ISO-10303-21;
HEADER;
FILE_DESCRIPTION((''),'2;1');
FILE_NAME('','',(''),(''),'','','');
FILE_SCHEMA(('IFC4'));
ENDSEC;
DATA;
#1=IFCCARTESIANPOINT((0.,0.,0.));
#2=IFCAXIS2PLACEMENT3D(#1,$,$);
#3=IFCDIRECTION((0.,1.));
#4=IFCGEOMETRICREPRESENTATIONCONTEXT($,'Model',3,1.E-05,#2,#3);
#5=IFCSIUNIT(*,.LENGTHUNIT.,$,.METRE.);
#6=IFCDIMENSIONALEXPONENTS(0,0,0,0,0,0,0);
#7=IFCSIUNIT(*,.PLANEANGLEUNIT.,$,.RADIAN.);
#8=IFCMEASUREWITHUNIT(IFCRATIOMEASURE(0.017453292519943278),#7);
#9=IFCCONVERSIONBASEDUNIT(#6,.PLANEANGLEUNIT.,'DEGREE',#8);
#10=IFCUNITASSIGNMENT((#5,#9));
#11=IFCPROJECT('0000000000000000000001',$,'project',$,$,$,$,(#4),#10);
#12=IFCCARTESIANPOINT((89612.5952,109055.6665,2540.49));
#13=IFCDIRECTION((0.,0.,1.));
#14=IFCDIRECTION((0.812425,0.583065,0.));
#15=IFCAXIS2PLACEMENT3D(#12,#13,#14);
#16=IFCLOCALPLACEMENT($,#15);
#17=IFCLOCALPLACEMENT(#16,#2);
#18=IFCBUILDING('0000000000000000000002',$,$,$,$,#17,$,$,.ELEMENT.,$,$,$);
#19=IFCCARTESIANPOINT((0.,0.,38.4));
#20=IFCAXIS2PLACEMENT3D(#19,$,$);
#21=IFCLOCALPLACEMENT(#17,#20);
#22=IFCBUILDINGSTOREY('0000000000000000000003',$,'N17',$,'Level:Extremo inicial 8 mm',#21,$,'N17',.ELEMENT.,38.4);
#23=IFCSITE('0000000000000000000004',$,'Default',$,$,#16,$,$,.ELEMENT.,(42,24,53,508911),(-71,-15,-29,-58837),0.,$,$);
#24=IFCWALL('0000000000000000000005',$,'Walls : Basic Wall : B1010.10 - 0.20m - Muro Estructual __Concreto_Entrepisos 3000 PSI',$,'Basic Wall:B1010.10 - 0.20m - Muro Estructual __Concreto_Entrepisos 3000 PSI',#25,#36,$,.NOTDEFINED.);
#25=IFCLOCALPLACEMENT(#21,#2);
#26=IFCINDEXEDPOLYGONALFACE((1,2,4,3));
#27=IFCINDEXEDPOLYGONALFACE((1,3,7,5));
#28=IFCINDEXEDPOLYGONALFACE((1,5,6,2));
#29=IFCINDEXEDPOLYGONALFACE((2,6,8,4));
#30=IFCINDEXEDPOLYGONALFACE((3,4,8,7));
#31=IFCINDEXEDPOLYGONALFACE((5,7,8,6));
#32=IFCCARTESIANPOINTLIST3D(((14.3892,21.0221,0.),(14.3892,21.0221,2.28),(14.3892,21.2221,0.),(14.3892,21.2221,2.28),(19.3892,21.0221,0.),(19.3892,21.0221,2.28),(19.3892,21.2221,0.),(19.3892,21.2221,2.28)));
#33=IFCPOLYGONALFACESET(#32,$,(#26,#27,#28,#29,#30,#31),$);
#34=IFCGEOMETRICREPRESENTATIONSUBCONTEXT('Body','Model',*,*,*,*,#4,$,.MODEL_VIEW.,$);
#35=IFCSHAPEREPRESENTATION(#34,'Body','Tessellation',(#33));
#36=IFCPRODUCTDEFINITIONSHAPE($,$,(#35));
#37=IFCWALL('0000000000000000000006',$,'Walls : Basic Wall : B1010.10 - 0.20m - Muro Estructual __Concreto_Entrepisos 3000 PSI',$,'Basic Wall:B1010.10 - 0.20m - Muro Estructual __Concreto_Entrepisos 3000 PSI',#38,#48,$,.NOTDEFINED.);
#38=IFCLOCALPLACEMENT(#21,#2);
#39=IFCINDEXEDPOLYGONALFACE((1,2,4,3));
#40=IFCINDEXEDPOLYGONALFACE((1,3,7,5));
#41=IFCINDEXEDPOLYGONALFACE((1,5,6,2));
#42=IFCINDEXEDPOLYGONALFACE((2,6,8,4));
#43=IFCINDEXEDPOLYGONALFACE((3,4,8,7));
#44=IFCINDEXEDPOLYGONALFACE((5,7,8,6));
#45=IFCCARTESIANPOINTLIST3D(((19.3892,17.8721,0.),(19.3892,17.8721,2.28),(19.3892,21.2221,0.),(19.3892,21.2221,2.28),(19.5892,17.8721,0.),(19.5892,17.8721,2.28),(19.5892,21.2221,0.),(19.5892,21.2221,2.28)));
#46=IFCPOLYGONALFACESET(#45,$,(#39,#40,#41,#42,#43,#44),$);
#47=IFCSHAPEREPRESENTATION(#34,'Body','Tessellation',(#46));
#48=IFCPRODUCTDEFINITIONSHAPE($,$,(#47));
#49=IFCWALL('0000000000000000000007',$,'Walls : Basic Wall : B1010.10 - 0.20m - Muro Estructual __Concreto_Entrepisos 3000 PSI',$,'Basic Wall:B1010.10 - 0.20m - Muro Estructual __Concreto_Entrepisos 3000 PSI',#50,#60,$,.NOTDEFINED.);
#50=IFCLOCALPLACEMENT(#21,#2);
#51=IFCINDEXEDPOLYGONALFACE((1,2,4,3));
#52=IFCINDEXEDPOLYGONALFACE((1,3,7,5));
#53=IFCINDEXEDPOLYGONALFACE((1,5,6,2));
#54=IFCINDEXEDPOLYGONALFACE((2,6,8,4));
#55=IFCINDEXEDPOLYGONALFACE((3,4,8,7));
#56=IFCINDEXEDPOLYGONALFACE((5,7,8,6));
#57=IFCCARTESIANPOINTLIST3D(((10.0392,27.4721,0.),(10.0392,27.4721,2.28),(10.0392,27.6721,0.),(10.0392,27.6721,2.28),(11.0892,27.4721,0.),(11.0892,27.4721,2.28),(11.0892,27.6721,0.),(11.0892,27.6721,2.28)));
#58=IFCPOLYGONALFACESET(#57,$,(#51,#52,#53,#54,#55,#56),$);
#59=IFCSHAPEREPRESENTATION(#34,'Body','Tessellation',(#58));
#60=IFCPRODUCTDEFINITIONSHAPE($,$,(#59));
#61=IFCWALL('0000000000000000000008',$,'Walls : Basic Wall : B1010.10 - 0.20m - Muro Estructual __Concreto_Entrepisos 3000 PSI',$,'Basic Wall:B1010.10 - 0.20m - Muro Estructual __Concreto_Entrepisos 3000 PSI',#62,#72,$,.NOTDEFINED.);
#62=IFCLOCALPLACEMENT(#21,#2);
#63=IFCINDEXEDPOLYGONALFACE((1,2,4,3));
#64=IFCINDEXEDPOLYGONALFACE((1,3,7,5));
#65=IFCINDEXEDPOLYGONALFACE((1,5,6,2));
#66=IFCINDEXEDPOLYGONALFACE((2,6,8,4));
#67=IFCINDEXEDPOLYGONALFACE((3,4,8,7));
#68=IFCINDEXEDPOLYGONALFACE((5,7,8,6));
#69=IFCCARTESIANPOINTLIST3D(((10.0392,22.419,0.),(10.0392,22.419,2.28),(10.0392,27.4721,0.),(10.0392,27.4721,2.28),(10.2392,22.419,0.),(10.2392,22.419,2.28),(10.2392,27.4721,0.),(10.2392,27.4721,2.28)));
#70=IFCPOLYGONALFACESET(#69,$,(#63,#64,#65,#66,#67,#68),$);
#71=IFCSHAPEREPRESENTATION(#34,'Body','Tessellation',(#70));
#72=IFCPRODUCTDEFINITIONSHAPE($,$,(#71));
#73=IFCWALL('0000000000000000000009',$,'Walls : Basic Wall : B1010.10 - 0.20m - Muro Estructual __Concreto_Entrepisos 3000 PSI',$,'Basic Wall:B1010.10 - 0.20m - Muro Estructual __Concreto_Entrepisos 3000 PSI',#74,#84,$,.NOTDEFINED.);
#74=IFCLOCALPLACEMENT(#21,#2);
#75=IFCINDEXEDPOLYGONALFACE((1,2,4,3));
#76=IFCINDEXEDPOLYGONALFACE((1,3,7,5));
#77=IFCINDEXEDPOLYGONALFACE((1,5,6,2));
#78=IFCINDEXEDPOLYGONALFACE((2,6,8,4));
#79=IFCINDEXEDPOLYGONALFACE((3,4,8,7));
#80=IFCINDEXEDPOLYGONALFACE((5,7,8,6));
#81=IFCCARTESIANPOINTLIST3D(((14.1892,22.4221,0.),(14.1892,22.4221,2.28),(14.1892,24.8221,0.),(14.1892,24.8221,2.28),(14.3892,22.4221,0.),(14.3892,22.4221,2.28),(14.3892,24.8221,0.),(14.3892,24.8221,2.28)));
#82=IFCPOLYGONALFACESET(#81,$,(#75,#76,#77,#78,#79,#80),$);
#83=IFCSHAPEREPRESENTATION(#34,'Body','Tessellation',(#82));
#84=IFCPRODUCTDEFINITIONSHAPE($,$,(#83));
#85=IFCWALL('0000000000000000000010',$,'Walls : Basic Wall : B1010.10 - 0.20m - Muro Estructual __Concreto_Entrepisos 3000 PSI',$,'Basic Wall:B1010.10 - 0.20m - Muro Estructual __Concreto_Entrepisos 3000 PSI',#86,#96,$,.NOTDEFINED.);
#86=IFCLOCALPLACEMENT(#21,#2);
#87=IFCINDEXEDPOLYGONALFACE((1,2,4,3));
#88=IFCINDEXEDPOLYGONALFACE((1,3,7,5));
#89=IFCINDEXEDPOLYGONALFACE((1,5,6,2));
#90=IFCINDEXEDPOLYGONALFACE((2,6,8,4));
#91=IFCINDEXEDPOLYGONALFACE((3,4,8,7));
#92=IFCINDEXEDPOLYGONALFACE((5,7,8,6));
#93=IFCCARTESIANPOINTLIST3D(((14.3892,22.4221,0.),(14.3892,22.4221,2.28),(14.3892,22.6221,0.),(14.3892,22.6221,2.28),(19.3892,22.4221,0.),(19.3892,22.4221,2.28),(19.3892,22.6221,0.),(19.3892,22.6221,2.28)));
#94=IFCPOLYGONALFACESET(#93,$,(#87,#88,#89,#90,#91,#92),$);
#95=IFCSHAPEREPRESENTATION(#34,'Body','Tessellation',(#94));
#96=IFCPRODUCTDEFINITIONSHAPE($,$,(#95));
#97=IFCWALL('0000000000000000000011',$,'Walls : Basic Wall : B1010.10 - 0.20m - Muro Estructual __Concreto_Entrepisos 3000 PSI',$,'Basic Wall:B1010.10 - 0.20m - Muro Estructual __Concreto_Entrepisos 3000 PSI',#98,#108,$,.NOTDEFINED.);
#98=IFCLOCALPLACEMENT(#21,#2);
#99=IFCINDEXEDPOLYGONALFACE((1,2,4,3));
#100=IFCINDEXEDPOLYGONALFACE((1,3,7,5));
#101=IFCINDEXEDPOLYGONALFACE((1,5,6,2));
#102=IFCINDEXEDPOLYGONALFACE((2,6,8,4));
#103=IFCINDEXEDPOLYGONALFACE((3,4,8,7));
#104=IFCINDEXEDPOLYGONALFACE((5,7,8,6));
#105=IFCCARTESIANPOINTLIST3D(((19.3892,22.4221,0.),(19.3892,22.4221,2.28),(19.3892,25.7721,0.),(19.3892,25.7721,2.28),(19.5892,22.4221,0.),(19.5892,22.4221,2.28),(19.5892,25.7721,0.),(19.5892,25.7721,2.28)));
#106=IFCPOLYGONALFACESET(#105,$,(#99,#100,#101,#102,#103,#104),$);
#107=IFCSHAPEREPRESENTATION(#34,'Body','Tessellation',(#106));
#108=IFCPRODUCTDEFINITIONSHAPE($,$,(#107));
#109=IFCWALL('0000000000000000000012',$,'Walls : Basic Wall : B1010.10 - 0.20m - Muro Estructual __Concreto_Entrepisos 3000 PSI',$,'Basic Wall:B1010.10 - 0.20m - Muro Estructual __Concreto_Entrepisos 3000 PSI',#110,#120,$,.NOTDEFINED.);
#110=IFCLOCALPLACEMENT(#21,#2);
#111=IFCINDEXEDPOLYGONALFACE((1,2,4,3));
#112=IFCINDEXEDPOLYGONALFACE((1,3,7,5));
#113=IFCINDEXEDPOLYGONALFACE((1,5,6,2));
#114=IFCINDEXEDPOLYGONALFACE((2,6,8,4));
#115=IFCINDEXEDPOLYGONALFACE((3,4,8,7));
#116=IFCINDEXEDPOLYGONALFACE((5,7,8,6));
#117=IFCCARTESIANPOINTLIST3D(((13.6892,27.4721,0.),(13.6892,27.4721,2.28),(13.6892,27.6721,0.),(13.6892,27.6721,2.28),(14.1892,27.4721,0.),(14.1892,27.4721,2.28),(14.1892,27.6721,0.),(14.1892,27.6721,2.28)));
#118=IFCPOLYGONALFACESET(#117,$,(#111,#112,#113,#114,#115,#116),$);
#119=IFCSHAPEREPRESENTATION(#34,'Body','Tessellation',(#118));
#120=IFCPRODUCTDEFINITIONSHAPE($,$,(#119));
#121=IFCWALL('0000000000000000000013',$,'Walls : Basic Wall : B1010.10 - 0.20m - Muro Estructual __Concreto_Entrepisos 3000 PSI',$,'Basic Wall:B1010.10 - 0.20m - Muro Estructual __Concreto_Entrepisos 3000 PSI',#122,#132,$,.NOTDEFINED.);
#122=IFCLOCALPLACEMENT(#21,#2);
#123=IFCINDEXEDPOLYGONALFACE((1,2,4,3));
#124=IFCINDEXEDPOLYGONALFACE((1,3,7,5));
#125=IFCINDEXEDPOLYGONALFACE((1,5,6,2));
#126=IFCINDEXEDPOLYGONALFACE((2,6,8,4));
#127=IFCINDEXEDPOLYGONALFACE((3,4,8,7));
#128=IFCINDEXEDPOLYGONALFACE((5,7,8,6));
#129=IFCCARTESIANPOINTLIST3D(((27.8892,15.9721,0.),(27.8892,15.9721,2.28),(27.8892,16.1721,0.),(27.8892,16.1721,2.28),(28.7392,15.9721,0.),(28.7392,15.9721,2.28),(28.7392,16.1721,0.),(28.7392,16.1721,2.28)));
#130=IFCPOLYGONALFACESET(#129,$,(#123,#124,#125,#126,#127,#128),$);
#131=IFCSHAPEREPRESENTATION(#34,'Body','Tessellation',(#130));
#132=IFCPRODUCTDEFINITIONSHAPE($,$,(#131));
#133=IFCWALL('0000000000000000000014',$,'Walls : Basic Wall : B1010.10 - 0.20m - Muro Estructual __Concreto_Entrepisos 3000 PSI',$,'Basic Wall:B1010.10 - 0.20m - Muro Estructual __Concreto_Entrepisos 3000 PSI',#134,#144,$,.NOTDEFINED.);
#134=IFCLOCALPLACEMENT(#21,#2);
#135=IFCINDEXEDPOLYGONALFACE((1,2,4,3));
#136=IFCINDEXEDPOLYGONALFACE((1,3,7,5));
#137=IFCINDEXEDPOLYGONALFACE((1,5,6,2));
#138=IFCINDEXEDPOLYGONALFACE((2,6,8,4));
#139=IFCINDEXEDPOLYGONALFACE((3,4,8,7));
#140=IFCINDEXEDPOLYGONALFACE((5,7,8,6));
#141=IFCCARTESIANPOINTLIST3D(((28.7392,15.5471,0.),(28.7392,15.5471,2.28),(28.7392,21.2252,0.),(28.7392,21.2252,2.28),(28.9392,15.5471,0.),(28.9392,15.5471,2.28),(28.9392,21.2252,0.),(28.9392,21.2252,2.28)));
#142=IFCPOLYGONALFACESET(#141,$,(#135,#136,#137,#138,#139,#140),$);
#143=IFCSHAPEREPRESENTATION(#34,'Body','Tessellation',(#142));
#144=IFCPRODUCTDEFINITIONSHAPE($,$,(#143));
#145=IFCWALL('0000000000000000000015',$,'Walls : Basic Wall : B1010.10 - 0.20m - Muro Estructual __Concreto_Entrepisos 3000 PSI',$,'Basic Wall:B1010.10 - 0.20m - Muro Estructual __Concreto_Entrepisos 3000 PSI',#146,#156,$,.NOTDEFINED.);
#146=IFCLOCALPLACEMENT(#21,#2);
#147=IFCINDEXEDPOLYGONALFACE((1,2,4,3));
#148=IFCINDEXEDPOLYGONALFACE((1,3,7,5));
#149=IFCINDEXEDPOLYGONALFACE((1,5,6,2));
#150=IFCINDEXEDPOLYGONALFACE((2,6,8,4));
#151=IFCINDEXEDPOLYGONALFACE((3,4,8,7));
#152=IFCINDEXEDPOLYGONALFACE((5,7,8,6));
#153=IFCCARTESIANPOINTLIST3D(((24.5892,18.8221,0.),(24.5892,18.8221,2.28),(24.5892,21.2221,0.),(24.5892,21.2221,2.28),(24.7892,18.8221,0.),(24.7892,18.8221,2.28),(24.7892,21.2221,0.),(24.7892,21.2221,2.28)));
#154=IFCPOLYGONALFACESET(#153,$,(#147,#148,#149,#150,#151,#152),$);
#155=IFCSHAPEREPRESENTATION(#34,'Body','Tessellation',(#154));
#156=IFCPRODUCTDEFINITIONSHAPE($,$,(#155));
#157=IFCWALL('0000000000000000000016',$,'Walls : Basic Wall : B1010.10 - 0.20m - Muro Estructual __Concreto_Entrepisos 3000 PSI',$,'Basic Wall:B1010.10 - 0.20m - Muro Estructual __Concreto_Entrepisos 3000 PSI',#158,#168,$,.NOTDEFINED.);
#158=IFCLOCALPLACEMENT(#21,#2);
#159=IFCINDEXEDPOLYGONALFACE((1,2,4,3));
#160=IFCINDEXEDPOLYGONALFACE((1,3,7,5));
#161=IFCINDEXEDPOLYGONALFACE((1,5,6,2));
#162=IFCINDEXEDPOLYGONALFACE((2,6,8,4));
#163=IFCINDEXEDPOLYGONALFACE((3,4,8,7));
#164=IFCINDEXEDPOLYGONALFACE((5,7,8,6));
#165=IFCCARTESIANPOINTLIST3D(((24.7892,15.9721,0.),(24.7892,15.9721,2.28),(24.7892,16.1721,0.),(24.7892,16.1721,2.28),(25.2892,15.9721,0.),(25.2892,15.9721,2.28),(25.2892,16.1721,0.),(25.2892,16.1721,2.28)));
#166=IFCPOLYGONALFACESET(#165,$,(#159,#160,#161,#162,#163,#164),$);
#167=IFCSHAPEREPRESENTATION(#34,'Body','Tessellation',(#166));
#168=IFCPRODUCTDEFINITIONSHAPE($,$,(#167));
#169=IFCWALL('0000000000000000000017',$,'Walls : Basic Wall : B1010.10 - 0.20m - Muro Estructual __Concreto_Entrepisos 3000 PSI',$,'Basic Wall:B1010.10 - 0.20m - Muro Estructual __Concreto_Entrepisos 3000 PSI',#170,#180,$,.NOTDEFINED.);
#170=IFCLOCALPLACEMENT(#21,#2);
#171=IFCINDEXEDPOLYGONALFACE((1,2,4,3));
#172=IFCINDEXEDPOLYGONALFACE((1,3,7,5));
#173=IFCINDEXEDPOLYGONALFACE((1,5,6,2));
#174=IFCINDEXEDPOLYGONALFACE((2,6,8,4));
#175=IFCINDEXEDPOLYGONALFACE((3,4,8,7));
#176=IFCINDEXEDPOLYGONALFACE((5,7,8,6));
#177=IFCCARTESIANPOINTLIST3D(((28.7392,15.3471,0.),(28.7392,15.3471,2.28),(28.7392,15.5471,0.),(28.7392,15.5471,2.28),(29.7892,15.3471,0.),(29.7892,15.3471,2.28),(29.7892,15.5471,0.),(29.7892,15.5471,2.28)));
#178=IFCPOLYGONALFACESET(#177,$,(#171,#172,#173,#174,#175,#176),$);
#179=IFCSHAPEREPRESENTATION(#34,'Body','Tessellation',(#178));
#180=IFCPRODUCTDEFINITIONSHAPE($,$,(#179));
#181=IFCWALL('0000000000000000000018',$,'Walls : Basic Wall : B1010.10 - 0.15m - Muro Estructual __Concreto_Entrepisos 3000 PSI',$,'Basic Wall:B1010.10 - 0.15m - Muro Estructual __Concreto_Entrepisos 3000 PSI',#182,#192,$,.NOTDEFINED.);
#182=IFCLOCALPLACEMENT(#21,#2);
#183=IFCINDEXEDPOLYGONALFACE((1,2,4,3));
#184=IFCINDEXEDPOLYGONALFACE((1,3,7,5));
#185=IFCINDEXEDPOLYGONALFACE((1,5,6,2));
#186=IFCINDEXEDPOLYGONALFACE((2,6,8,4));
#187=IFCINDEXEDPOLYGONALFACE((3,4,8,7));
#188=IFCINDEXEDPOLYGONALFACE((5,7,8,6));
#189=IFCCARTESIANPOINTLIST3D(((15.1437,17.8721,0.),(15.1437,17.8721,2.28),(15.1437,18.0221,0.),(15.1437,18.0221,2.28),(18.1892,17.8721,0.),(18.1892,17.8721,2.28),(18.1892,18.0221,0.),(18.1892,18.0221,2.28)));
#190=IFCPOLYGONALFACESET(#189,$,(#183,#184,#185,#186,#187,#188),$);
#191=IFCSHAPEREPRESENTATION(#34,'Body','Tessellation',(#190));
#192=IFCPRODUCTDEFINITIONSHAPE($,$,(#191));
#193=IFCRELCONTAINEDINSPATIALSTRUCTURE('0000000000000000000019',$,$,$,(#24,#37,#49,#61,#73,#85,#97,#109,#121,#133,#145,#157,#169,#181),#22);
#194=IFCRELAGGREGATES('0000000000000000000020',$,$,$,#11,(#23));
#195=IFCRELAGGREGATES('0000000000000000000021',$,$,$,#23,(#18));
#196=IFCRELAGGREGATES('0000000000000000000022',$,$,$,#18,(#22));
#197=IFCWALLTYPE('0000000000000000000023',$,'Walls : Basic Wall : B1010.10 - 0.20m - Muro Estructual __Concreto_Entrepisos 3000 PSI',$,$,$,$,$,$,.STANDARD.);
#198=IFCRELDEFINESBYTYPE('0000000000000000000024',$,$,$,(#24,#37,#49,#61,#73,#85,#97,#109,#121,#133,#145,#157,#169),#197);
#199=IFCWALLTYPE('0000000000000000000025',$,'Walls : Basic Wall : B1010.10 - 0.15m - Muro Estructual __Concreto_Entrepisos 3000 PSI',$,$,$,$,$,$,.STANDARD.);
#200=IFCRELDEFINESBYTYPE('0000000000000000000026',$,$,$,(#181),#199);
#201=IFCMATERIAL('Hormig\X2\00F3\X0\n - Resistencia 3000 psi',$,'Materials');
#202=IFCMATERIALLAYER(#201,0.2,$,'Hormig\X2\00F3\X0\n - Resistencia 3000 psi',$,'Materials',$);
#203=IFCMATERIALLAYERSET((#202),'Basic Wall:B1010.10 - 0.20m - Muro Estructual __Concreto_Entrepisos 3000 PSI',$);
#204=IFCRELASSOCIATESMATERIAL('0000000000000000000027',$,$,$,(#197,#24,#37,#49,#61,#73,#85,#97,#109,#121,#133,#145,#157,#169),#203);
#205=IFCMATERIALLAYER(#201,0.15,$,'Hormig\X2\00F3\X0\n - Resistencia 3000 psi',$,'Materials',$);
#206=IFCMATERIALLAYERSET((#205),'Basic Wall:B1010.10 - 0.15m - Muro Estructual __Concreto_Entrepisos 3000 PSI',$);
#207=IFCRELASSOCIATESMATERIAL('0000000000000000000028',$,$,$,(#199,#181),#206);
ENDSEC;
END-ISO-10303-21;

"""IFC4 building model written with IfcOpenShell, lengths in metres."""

from ifc_helpers import new_model, entity, si_unit, converted_unit, direction, frame, frame_2d, origin, place, context, subcontext, project, spatial, rectangle, extrude, material, layer, layer_set, layer_usage, type_object, element, save


model = new_model("IFC4")

# Units and contexts
model_context = context("Model", 3, precision=1e-05, world=origin(), true_north=direction((0.0, 1.0)))
body_context = subcontext(model_context, "Body", "Model", "MODEL_VIEW")
ifc_project = project(units=[si_unit("LENGTHUNIT", "METRE"), converted_unit("PLANEANGLEUNIT", "DEGREE", entity("IfcRatioMeasure", 0.017453292519943278), si_unit("PLANEANGLEUNIT", "RADIAN"), dimensions=[0, 0, 0, 0, 0, 0, 0])], contexts=[model_context])

# Site, building, storey
site_placement = place(None, frame((89612.5952, 109055.6665, 2540.49), z_axis=(0.0, 0.0, 1.0), x_axis=(0.812425, 0.583065, 0.0)))
site = spatial("IfcSite", under=ifc_project, at=site_placement, Name="Default", CompositionType="ELEMENT", RefLatitude=(42, 24, 53, 508911), RefLongitude=(-71, -15, -29, -58837), RefElevation=0.0)
building_placement = place(site_placement, origin())
building = spatial("IfcBuilding", under=site, at=building_placement, CompositionType="ELEMENT")
storey_placement = place(building_placement, frame((0.0, 0.0, 38.4)))
storey = spatial("IfcBuildingStorey", under=building, at=storey_placement, Name="N17", ObjectType="Level:Extremo inicial 8 mm", LongName="N17", CompositionType="ELEMENT", Elevation=38.4)

# Walls
ifc_material = material(Name="Hormigón - Resistencia 3000 psi", Category="Materials")
ifc_layer_1 = layer(ifc_material, 0.2, Name="Hormigón - Resistencia 3000 psi", Category="Materials")
ifc_layer_set_1 = layer_set([ifc_layer_1], Name="Basic Wall:B1010.10 - 0.20m - Muro Estructual __Concreto_Entrepisos 3000 PSI")
ifc_layer_usage_1 = layer_usage(ifc_layer_set_1, "AXIS2", "NEGATIVE", 0.1)
wall_type_1 = type_object("IfcWallType", Name="Walls : Basic Wall : B1010.10 - 0.20m - Muro Estructual __Concreto_Entrepisos 3000 PSI", PredefinedType="STANDARD", material=ifc_layer_set_1)
wall_1_placement = place(storey_placement, frame((14.3892, 21.1221, 0.0)))
element("IfcWall", 1, at=wall_1_placement, inside=storey, type_object=wall_type_1, material=ifc_layer_usage_1, Name="Walls : Basic Wall : B1010.10 - 0.20m - Muro Estructual __Concreto_Entrepisos 3000 PSI", ObjectType="Basic Wall:B1010.10 - 0.20m - Muro Estructual __Concreto_Entrepisos 3000 PSI", PredefinedType="NOTDEFINED", context=body_context, shape_type="SweptSolid", body=[
    extrude(rectangle(XDim=5.0, YDim=0.2, at=frame_2d((2.5, 0.0), x_axis=(-1.0, 0.0))), origin(), (0.0, 0.0, 1.0), 2.28),
])
ifc_layer_usage_2 = layer_usage(ifc_layer_set_1, "AXIS2", "NEGATIVE", 0.1)
wall_2_placement = place(storey_placement, frame((19.4892, 21.2221, 0.0), z_axis=(0.0, 0.0, 1.0), x_axis=(0.0, -1.0, 0.0)))
element("IfcWall", 2, at=wall_2_placement, inside=storey, type_object=wall_type_1, material=ifc_layer_usage_2, Name="Walls : Basic Wall : B1010.10 - 0.20m - Muro Estructual __Concreto_Entrepisos 3000 PSI", ObjectType="Basic Wall:B1010.10 - 0.20m - Muro Estructual __Concreto_Entrepisos 3000 PSI", PredefinedType="NOTDEFINED", context=body_context, shape_type="SweptSolid", body=[
    extrude(rectangle(XDim=3.35, YDim=0.2, at=frame_2d((1.675, 0.0), x_axis=(-1.0, 0.0))), origin(), (0.0, 0.0, 1.0), 2.28),
])
ifc_layer_usage_3 = layer_usage(ifc_layer_set_1, "AXIS2", "POSITIVE", -0.1)
wall_3_placement = place(storey_placement, frame((11.0892, 27.5721, 0.0), z_axis=(0.0, 0.0, 1.0), x_axis=(-1.0, 0.0, 0.0)))
element("IfcWall", 3, at=wall_3_placement, inside=storey, type_object=wall_type_1, material=ifc_layer_usage_3, Name="Walls : Basic Wall : B1010.10 - 0.20m - Muro Estructual __Concreto_Entrepisos 3000 PSI", ObjectType="Basic Wall:B1010.10 - 0.20m - Muro Estructual __Concreto_Entrepisos 3000 PSI", PredefinedType="NOTDEFINED", context=body_context, shape_type="SweptSolid", body=[
    extrude(rectangle(XDim=1.05, YDim=0.2, at=frame_2d((0.525, 0.0), x_axis=(-1.0, 0.0))), origin(), (0.0, 0.0, 1.0), 2.28),
])
ifc_layer_usage_4 = layer_usage(ifc_layer_set_1, "AXIS2", "POSITIVE", -0.1)
wall_4_placement = place(storey_placement, frame((10.1392, 27.4721, 0.0), z_axis=(0.0, 0.0, 1.0), x_axis=(0.0, -1.0, 0.0)))
element("IfcWall", 4, at=wall_4_placement, inside=storey, type_object=wall_type_1, material=ifc_layer_usage_4, Name="Walls : Basic Wall : B1010.10 - 0.20m - Muro Estructual __Concreto_Entrepisos 3000 PSI", ObjectType="Basic Wall:B1010.10 - 0.20m - Muro Estructual __Concreto_Entrepisos 3000 PSI", PredefinedType="NOTDEFINED", context=body_context, shape_type="SweptSolid", body=[
    extrude(rectangle(XDim=5.0531, YDim=0.2, at=frame_2d((2.5265, 0.0), x_axis=(-1.0, 0.0))), origin(), (0.0, 0.0, 1.0), 2.28),
])
ifc_layer_usage_5 = layer_usage(ifc_layer_set_1, "AXIS2", "POSITIVE", -0.1)
wall_5_placement = place(storey_placement, frame((14.2892, 24.8221, 0.0), z_axis=(0.0, 0.0, 1.0), x_axis=(0.0, -1.0, 0.0)))
element("IfcWall", 5, at=wall_5_placement, inside=storey, type_object=wall_type_1, material=ifc_layer_usage_5, Name="Walls : Basic Wall : B1010.10 - 0.20m - Muro Estructual __Concreto_Entrepisos 3000 PSI", ObjectType="Basic Wall:B1010.10 - 0.20m - Muro Estructual __Concreto_Entrepisos 3000 PSI", PredefinedType="NOTDEFINED", context=body_context, shape_type="SweptSolid", body=[
    extrude(rectangle(XDim=2.4, YDim=0.2, at=frame_2d((1.2, 0.0), x_axis=(-1.0, 0.0))), origin(), (0.0, 0.0, 1.0), 2.28),
])
ifc_layer_usage_6 = layer_usage(ifc_layer_set_1, "AXIS2", "POSITIVE", -0.1)
wall_6_placement = place(storey_placement, frame((14.3892, 22.5221, 0.0)))
element("IfcWall", 6, at=wall_6_placement, inside=storey, type_object=wall_type_1, material=ifc_layer_usage_6, Name="Walls : Basic Wall : B1010.10 - 0.20m - Muro Estructual __Concreto_Entrepisos 3000 PSI", ObjectType="Basic Wall:B1010.10 - 0.20m - Muro Estructual __Concreto_Entrepisos 3000 PSI", PredefinedType="NOTDEFINED", context=body_context, shape_type="SweptSolid", body=[
    extrude(rectangle(XDim=5.0, YDim=0.2, at=frame_2d((2.5, 0.0), x_axis=(-1.0, 0.0))), origin(), (0.0, 0.0, 1.0), 2.28),
])
ifc_layer_usage_7 = layer_usage(ifc_layer_set_1, "AXIS2", "POSITIVE", -0.1)
wall_7_placement = place(storey_placement, frame((19.4892, 22.4221, 0.0), z_axis=(0.0, 0.0, 1.0), x_axis=(0.0, 1.0, 0.0)))
element("IfcWall", 7, at=wall_7_placement, inside=storey, type_object=wall_type_1, material=ifc_layer_usage_7, Name="Walls : Basic Wall : B1010.10 - 0.20m - Muro Estructual __Concreto_Entrepisos 3000 PSI", ObjectType="Basic Wall:B1010.10 - 0.20m - Muro Estructual __Concreto_Entrepisos 3000 PSI", PredefinedType="NOTDEFINED", context=body_context, shape_type="SweptSolid", body=[
    extrude(rectangle(XDim=3.35, YDim=0.2, at=frame_2d((1.675, 0.0), x_axis=(-1.0, 0.0))), origin(), (0.0, 0.0, 1.0), 2.28),
])
ifc_layer_usage_8 = layer_usage(ifc_layer_set_1, "AXIS2", "POSITIVE", -0.1)
wall_8_placement = place(storey_placement, frame((13.6892, 27.5721, 0.0)))
element("IfcWall", 8, at=wall_8_placement, inside=storey, type_object=wall_type_1, material=ifc_layer_usage_8, Name="Walls : Basic Wall : B1010.10 - 0.20m - Muro Estructual __Concreto_Entrepisos 3000 PSI", ObjectType="Basic Wall:B1010.10 - 0.20m - Muro Estructual __Concreto_Entrepisos 3000 PSI", PredefinedType="NOTDEFINED", context=body_context, shape_type="SweptSolid", body=[
    extrude(rectangle(XDim=0.5, YDim=0.2, at=frame_2d((0.25, 0.0), x_axis=(-1.0, 0.0))), origin(), (0.0, 0.0, 1.0), 2.28),
])
ifc_layer_usage_9 = layer_usage(ifc_layer_set_1, "AXIS2", "POSITIVE", -0.1)
wall_9_placement = place(storey_placement, frame((27.8892, 16.0721, 0.0)))
element("IfcWall", 9, at=wall_9_placement, inside=storey, type_object=wall_type_1, material=ifc_layer_usage_9, Name="Walls : Basic Wall : B1010.10 - 0.20m - Muro Estructual __Concreto_Entrepisos 3000 PSI", ObjectType="Basic Wall:B1010.10 - 0.20m - Muro Estructual __Concreto_Entrepisos 3000 PSI", PredefinedType="NOTDEFINED", context=body_context, shape_type="SweptSolid", body=[
    extrude(rectangle(XDim=0.85, YDim=0.2, at=frame_2d((0.425, 0.0), x_axis=(-1.0, 0.0))), origin(), (0.0, 0.0, 1.0), 2.28),
])
ifc_layer_usage_10 = layer_usage(ifc_layer_set_1, "AXIS2", "POSITIVE", -0.1)
wall_10_placement = place(storey_placement, frame((28.8392, 15.5471, 0.0), z_axis=(0.0, 0.0, 1.0), x_axis=(0.0, 1.0, 0.0)))
element("IfcWall", 10, at=wall_10_placement, inside=storey, type_object=wall_type_1, material=ifc_layer_usage_10, Name="Walls : Basic Wall : B1010.10 - 0.20m - Muro Estructual __Concreto_Entrepisos 3000 PSI", ObjectType="Basic Wall:B1010.10 - 0.20m - Muro Estructual __Concreto_Entrepisos 3000 PSI", PredefinedType="NOTDEFINED", context=body_context, shape_type="SweptSolid", body=[
    extrude(rectangle(XDim=5.6781, YDim=0.2, at=frame_2d((2.839, 0.0), x_axis=(-1.0, 0.0))), origin(), (0.0, 0.0, 1.0), 2.28),
])
ifc_layer_usage_11 = layer_usage(ifc_layer_set_1, "AXIS2", "POSITIVE", -0.1)
wall_11_placement = place(storey_placement, frame((24.6892, 18.8221, 0.0), z_axis=(0.0, 0.0, 1.0), x_axis=(0.0, 1.0, 0.0)))
element("IfcWall", 11, at=wall_11_placement, inside=storey, type_object=wall_type_1, material=ifc_layer_usage_11, Name="Walls : Basic Wall : B1010.10 - 0.20m - Muro Estructual __Concreto_Entrepisos 3000 PSI", ObjectType="Basic Wall:B1010.10 - 0.20m - Muro Estructual __Concreto_Entrepisos 3000 PSI", PredefinedType="NOTDEFINED", context=body_context, shape_type="SweptSolid", body=[
    extrude(rectangle(XDim=2.4, YDim=0.2, at=frame_2d((1.2, 0.0), x_axis=(-1.0, 0.0))), origin(), (0.0, 0.0, 1.0), 2.28),
])
ifc_layer_usage_12 = layer_usage(ifc_layer_set_1, "AXIS2", "POSITIVE", -0.1)
wall_12_placement = place(storey_placement, frame((25.2892, 16.0721, 0.0), z_axis=(0.0, 0.0, 1.0), x_axis=(-1.0, 0.0, 0.0)))
element("IfcWall", 12, at=wall_12_placement, inside=storey, type_object=wall_type_1, material=ifc_layer_usage_12, Name="Walls : Basic Wall : B1010.10 - 0.20m - Muro Estructual __Concreto_Entrepisos 3000 PSI", ObjectType="Basic Wall:B1010.10 - 0.20m - Muro Estructual __Concreto_Entrepisos 3000 PSI", PredefinedType="NOTDEFINED", context=body_context, shape_type="SweptSolid", body=[
    extrude(rectangle(XDim=0.5, YDim=0.2, at=frame_2d((0.25, 0.0), x_axis=(-1.0, 0.0))), origin(), (0.0, 0.0, 1.0), 2.28),
])
ifc_layer_usage_13 = layer_usage(ifc_layer_set_1, "AXIS2", "NEGATIVE", 0.1)
wall_13_placement = place(storey_placement, frame((29.7892, 15.4471, 0.0), z_axis=(0.0, 0.0, 1.0), x_axis=(-1.0, 0.0, 0.0)))
element("IfcWall", 13, at=wall_13_placement, inside=storey, type_object=wall_type_1, material=ifc_layer_usage_13, Name="Walls : Basic Wall : B1010.10 - 0.20m - Muro Estructual __Concreto_Entrepisos 3000 PSI", ObjectType="Basic Wall:B1010.10 - 0.20m - Muro Estructual __Concreto_Entrepisos 3000 PSI", PredefinedType="NOTDEFINED", context=body_context, shape_type="SweptSolid", body=[
    extrude(rectangle(XDim=1.05, YDim=0.2, at=frame_2d((0.525, 0.0), x_axis=(-1.0, 0.0))), origin(), (0.0, 0.0, 1.0), 2.28),
])
ifc_layer_2 = layer(ifc_material, 0.15, Name="Hormigón - Resistencia 3000 psi", Category="Materials")
ifc_layer_set_2 = layer_set([ifc_layer_2], Name="Basic Wall:B1010.10 - 0.15m - Muro Estructual __Concreto_Entrepisos 3000 PSI")
ifc_layer_usage_14 = layer_usage(ifc_layer_set_2, "AXIS2", "NEGATIVE", 0.075)
wall_type_2 = type_object("IfcWallType", Name="Walls : Basic Wall : B1010.10 - 0.15m - Muro Estructual __Concreto_Entrepisos 3000 PSI", PredefinedType="STANDARD", material=ifc_layer_set_2)
wall_14_placement = place(storey_placement, frame((18.1892, 17.9471, 0.0), z_axis=(0.0, 0.0, 1.0), x_axis=(-1.0, 0.0, 0.0)))
element("IfcWall", 14, at=wall_14_placement, inside=storey, type_object=wall_type_2, material=ifc_layer_usage_14, Name="Walls : Basic Wall : B1010.10 - 0.15m - Muro Estructual __Concreto_Entrepisos 3000 PSI", ObjectType="Basic Wall:B1010.10 - 0.15m - Muro Estructual __Concreto_Entrepisos 3000 PSI", PredefinedType="NOTDEFINED", context=body_context, shape_type="SweptSolid", body=[
    extrude(rectangle(XDim=3.0455, YDim=0.15, at=frame_2d((1.5228, 0.0), x_axis=(-1.0, 0.0))), origin(), (0.0, 0.0, 1.0), 2.28),
])

save(model, "model.ifc")
